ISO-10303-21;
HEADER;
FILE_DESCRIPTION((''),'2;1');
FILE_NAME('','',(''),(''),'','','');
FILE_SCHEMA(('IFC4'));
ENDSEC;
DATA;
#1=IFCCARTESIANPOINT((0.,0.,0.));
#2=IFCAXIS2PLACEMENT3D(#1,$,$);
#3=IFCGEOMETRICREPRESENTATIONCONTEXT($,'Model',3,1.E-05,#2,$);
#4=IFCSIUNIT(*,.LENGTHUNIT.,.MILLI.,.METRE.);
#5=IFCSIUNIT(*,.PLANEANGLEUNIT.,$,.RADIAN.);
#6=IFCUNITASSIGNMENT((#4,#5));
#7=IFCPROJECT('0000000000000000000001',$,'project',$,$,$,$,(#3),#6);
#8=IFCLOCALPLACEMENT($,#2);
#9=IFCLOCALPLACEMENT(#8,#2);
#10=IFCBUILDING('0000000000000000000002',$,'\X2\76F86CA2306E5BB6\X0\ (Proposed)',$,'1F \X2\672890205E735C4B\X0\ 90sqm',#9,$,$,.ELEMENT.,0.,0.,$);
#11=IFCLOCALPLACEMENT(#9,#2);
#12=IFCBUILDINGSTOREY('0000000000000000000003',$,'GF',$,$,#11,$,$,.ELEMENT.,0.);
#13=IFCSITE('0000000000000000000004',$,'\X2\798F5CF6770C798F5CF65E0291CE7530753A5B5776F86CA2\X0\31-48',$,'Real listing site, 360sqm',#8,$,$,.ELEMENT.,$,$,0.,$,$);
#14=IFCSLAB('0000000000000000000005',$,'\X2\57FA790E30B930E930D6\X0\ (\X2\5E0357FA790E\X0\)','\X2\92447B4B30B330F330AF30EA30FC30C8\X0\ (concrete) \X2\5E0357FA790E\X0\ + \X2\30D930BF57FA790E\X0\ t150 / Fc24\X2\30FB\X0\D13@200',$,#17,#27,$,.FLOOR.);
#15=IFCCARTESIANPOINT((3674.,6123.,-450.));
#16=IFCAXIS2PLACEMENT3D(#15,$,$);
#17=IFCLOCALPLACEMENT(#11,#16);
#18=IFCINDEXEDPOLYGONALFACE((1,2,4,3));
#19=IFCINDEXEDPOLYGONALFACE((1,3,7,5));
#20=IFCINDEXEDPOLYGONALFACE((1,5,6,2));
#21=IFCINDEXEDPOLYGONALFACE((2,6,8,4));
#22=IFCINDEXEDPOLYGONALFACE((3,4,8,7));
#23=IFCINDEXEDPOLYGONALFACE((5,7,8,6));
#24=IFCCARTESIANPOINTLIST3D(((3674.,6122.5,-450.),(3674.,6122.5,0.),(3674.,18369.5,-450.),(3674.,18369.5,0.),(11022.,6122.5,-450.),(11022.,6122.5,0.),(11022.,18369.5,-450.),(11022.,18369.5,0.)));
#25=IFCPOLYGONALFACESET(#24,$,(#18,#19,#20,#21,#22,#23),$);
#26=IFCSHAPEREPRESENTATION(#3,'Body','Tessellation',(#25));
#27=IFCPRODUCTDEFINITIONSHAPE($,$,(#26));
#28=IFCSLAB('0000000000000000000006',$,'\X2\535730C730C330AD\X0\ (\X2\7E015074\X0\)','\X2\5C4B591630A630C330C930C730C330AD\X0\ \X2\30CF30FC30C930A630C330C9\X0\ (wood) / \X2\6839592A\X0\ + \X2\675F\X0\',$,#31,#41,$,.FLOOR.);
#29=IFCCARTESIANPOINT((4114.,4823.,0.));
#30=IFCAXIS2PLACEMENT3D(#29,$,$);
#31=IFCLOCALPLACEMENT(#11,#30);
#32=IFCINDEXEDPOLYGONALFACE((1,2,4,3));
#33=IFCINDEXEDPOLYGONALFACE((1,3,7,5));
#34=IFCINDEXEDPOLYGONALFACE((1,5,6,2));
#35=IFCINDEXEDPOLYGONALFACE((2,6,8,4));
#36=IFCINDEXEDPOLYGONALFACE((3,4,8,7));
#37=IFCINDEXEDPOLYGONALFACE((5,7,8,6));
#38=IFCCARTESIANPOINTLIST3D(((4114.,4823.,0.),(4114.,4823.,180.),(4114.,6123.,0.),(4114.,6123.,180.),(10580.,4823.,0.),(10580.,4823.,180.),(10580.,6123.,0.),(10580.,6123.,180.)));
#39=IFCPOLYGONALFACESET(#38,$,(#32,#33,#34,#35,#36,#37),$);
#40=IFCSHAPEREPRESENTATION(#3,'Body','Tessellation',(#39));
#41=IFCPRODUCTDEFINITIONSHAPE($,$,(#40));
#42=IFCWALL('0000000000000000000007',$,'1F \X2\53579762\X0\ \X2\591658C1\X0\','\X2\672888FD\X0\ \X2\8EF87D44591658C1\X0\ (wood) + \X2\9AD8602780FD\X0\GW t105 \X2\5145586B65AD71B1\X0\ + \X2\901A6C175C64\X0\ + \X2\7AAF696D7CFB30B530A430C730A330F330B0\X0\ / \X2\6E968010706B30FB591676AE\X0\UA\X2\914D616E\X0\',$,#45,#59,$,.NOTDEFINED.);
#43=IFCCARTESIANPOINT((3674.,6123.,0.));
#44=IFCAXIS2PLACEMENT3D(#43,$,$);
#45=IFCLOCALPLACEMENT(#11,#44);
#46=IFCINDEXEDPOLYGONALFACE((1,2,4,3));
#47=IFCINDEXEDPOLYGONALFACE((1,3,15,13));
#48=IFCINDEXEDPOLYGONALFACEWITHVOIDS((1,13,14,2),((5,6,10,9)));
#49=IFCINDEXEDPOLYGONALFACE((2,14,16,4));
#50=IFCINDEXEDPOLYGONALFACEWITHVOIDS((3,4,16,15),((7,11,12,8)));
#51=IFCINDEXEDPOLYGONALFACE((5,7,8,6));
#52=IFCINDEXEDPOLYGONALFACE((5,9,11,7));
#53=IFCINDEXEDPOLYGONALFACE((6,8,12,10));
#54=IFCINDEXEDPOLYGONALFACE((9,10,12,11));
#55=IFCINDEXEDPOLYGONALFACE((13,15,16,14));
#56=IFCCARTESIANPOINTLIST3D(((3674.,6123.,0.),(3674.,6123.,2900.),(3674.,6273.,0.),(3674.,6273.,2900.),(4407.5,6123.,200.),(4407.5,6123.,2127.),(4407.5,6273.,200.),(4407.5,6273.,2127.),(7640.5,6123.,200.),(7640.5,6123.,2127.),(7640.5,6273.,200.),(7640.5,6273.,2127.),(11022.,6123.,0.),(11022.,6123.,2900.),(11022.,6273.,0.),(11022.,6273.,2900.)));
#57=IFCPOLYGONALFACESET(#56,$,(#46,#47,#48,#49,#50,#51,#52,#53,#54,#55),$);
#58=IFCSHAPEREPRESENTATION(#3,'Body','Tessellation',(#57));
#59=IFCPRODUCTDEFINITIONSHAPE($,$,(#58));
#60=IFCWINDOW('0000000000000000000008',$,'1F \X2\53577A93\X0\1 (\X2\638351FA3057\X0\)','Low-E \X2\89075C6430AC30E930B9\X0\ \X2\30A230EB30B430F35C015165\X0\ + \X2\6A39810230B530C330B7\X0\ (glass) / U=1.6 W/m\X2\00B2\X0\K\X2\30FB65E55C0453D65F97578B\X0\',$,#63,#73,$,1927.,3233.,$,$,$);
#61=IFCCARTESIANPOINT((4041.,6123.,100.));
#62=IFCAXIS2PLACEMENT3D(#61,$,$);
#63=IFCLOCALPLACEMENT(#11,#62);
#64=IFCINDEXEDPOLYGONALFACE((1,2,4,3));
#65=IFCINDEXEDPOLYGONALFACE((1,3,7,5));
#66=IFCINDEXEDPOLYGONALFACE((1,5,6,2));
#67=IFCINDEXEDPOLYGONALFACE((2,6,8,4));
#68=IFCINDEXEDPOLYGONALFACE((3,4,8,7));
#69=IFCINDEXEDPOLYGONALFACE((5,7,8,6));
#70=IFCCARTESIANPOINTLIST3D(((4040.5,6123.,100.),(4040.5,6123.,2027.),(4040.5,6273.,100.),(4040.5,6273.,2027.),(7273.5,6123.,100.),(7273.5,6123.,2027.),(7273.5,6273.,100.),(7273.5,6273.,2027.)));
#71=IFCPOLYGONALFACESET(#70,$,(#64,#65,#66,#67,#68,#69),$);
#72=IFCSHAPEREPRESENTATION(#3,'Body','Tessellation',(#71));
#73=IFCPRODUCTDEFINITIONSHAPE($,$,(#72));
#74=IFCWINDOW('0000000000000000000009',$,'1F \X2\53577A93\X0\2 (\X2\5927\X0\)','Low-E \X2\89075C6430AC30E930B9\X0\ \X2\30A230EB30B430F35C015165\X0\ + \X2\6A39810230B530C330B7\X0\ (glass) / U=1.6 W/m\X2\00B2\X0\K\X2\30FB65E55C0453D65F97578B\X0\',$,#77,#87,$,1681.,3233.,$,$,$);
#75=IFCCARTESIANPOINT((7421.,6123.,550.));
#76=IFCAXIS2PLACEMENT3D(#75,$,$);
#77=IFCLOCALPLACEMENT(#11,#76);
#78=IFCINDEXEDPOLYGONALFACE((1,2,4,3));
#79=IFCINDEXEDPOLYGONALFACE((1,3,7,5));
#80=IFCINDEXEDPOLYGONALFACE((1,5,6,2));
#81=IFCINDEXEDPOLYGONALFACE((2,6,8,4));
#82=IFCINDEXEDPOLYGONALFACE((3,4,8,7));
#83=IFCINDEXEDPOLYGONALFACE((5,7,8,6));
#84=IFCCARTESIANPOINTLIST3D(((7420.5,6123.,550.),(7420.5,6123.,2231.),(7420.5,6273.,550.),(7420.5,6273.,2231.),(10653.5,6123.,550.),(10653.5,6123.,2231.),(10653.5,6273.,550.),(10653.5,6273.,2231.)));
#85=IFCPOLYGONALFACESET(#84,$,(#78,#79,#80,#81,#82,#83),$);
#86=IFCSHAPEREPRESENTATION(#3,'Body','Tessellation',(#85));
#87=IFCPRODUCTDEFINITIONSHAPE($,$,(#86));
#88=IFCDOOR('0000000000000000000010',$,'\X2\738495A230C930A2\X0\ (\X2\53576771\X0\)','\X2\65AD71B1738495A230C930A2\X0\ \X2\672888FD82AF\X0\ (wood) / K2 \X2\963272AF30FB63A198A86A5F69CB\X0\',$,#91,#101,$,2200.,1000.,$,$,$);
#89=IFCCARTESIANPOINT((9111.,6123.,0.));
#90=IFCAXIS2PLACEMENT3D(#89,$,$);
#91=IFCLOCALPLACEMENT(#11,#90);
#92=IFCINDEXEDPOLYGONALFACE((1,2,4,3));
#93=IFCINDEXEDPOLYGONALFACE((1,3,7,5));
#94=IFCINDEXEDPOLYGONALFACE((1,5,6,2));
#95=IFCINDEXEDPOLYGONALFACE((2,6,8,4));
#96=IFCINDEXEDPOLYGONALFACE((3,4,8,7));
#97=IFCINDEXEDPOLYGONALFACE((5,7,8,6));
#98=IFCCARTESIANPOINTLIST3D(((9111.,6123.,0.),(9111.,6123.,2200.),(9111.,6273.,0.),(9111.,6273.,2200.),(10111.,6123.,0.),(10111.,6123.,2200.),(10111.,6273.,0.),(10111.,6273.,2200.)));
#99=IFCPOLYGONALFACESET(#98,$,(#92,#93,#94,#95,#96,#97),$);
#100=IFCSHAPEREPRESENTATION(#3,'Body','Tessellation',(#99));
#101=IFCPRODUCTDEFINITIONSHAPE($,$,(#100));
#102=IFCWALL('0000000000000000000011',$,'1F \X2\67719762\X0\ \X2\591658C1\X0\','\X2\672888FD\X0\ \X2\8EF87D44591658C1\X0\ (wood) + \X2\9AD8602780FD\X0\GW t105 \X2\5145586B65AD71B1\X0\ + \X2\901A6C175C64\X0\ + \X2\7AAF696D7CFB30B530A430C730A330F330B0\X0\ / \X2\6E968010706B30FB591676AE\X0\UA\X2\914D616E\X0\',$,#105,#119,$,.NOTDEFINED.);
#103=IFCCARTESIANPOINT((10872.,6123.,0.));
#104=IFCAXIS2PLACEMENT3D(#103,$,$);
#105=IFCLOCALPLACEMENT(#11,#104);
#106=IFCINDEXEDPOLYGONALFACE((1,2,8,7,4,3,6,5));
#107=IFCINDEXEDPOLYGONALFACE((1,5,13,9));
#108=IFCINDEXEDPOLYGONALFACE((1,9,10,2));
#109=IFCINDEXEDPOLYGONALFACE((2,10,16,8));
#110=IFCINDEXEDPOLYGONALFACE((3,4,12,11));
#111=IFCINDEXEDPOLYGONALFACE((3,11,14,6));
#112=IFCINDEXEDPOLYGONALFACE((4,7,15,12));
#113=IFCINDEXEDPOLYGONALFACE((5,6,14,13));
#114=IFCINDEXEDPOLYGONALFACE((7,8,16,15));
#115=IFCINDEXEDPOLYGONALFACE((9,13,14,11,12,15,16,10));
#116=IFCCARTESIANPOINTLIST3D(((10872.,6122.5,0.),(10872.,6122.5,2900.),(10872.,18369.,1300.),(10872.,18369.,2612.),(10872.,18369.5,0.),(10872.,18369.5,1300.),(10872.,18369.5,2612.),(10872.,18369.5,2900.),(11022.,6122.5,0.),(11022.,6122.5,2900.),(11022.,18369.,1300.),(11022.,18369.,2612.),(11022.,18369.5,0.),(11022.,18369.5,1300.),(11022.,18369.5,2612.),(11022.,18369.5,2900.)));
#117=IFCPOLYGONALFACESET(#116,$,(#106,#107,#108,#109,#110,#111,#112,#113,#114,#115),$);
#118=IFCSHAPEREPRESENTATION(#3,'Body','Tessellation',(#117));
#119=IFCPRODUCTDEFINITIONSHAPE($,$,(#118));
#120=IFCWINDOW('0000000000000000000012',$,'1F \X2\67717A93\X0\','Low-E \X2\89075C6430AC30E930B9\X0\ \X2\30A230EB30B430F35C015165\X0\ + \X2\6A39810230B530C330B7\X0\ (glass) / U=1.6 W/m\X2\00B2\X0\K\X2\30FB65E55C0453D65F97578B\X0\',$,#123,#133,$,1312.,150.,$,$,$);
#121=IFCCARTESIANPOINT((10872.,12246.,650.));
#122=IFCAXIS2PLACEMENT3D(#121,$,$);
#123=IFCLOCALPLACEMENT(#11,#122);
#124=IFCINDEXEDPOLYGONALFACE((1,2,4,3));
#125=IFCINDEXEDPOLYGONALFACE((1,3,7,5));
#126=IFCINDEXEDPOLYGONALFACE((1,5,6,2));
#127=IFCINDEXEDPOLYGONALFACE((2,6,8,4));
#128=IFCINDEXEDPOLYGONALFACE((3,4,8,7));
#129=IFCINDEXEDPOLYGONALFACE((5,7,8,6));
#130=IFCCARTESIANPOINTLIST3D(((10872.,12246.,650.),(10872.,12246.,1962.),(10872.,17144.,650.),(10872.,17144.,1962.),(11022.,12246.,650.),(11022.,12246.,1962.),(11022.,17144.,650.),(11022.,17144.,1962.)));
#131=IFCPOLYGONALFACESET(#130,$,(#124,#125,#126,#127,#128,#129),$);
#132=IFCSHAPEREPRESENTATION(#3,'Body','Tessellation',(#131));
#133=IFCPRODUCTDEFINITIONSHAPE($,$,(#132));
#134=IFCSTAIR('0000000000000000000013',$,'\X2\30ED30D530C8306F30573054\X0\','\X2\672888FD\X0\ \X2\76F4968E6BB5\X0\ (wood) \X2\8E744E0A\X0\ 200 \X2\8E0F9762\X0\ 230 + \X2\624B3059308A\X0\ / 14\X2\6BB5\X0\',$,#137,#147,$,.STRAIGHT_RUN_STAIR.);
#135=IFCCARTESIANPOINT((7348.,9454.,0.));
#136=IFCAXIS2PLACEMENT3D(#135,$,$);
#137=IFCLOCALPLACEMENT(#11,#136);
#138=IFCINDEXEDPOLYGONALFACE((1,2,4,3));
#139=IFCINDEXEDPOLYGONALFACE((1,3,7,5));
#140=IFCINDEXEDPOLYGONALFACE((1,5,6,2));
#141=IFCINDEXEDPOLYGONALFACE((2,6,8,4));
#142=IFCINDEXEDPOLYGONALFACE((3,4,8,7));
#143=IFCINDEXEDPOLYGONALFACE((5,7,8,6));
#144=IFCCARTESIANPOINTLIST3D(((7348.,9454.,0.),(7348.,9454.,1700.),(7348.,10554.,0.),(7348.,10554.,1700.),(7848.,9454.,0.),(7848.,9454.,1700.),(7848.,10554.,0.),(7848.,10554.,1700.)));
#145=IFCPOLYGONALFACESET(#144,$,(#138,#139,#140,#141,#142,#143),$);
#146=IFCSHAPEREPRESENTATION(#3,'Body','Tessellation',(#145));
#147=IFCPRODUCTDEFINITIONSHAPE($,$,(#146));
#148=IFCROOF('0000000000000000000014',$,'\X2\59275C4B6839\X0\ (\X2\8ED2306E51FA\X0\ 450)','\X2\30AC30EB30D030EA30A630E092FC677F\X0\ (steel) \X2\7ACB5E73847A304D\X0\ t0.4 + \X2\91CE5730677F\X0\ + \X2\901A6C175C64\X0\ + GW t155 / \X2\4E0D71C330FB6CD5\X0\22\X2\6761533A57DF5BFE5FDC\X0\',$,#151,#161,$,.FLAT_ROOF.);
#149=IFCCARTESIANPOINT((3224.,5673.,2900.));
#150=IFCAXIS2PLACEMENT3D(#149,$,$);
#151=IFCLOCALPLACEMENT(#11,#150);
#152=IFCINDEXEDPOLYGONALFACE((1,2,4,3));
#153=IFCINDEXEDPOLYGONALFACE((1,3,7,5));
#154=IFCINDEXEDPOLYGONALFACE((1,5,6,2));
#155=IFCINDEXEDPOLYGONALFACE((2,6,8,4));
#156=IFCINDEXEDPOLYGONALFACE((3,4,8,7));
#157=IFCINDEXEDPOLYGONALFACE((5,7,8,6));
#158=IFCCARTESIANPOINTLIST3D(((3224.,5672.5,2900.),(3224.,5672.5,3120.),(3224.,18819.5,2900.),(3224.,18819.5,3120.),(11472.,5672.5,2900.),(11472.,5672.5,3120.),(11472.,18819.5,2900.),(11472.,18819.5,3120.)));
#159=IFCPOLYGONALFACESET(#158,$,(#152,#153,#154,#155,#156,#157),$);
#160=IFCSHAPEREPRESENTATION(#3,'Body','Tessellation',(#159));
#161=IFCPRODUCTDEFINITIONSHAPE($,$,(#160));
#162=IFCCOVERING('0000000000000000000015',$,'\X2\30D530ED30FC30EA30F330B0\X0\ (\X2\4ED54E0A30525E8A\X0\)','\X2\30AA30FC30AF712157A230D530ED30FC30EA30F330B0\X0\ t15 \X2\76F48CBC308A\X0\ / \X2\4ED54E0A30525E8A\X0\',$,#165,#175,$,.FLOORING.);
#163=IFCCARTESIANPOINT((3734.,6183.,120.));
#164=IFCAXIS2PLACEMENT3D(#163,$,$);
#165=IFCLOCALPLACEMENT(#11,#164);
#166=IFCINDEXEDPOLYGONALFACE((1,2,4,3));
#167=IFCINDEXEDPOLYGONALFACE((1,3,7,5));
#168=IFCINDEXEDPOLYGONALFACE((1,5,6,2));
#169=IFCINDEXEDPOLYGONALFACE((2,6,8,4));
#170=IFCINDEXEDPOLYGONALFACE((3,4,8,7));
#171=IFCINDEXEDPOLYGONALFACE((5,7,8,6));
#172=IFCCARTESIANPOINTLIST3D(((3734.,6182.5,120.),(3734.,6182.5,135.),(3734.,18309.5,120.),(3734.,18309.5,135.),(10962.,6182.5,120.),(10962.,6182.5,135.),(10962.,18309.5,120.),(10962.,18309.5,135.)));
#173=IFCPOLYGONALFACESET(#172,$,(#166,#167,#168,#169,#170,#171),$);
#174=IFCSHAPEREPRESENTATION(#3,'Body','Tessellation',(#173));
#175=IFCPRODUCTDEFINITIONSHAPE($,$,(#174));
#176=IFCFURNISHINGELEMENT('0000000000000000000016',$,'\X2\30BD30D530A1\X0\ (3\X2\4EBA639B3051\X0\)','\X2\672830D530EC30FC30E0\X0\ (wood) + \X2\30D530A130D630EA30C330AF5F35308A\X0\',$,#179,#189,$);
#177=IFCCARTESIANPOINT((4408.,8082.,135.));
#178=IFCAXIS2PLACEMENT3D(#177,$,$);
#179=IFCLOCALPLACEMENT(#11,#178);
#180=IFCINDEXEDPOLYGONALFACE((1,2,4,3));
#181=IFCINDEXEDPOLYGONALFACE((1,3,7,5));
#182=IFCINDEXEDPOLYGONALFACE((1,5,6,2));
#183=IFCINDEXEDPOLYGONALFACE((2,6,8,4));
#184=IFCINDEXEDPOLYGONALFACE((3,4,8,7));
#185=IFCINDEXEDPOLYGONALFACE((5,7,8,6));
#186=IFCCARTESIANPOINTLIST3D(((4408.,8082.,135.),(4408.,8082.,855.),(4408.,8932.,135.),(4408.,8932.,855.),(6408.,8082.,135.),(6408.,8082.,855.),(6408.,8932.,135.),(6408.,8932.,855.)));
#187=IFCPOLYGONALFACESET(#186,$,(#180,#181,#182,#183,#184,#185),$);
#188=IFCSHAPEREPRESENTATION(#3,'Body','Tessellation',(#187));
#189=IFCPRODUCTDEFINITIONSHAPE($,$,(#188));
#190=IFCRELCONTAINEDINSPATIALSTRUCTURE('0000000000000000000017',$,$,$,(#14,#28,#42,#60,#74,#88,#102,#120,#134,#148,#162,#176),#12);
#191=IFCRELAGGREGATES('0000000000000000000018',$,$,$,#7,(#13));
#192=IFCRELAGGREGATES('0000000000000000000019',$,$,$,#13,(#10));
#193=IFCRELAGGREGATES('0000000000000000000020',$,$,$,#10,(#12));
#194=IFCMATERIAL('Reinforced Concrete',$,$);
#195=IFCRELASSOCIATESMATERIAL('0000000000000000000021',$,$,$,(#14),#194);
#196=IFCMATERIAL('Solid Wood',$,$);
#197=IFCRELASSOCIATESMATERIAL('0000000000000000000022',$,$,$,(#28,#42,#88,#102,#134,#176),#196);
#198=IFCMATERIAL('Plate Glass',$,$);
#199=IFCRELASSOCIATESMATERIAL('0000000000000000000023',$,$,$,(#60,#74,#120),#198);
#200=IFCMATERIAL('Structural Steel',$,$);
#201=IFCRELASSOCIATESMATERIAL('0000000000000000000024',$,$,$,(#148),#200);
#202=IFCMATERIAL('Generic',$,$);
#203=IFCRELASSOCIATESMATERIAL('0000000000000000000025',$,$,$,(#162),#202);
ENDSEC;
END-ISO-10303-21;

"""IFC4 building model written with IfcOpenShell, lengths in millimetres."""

from ifc_helpers import new_model, si_unit, frame, frame_2d, origin, place, context, project, spatial, rectangle, extrude, material, element, fill, save


model = new_model("IFC4")

# Units and contexts
model_context = context("Model", 3, precision=1e-05, world=origin())
ifc_project = project(units=[si_unit("LENGTHUNIT", "METRE", prefix="MILLI"), si_unit("PLANEANGLEUNIT", "RADIAN")], contexts=[model_context])

# Site, building, storey
site_placement = place(None, origin())
site = spatial("IfcSite", under=ifc_project, at=site_placement, Name="福島県福島市野田町字相沢31-48", ObjectType="Real listing site, 360sqm", CompositionType="ELEMENT", RefElevation=0.0)
building_placement = place(site_placement, origin())
building = spatial("IfcBuilding", under=site, at=building_placement, Name="相沢の家 (Proposed)", ObjectType="1F 木造平屋 90sqm", CompositionType="ELEMENT", ElevationOfRefHeight=0.0, ElevationOfTerrain=0.0)
storey_placement = place(building_placement, origin())
storey = spatial("IfcBuildingStorey", under=building, at=storey_placement, Name="GF", CompositionType="ELEMENT", Elevation=0.0)

# Slabs
ifc_material_1 = material(Name="Reinforced Concrete")
slab_1_placement = place(storey_placement, frame((3674.0, 6123.0, -450.0)))
element("IfcSlab", 1, at=slab_1_placement, inside=storey, material=ifc_material_1, Name="基礎スラブ (布基礎)", Description="鉄筋コンクリート (concrete) 布基礎 + ベタ基礎 t150 / Fc24・D13@200", PredefinedType="FLOOR", context=model_context, shape_type="SweptSolid", body=[
    extrude(rectangle(XDim=7348.0, YDim=12247.0, at=frame_2d((3674.0, 6123.0))), frame((3674.0, 6123.0, -450.0)), (0.0, 0.0, 1.0), 450.0),
])
ifc_material_2 = material(Name="Solid Wood")
slab_2_placement = place(storey_placement, frame((4114.0, 4823.0, 0.0)))
element("IfcSlab", 2, at=slab_2_placement, inside=storey, material=ifc_material_2, Name="南デッキ (縁側)", Description="屋外ウッドデッキ ハードウッド (wood) / 根太 + 束", PredefinedType="FLOOR", context=model_context, shape_type="SweptSolid", body=[
    extrude(rectangle(XDim=6466.0, YDim=1300.0, at=frame_2d((3233.0, 650.0))), frame((4114.0, 4823.0, 0.0)), (0.0, 0.0, 1.0), 180.0),
])

# Wall, openings, windows, door
wall_1_placement = place(storey_placement, frame((3674.0, 6123.0, 0.0)))
wall_1 = element("IfcWall", 3, at=wall_1_placement, inside=storey, material=ifc_material_2, Name="1F 南面 外壁", Description="木製 軸組外壁 (wood) + 高性能GW t105 充填断熱 + 通気層 + 窯業系サイディング / 準耐火・外皮UA配慮", PredefinedType="NOTDEFINED", context=model_context, shape_type="SweptSolid", body=[
    extrude(rectangle(XDim=7348.0, YDim=150.0, at=frame_2d((3674.0, 75.0))), frame((3674.0, 6123.0, 0.0)), (0.0, 0.0, 1.0), 2900.0),
])
opening_1_placement = place(storey_placement, frame((4041.0, 6123.0, 100.0)))
opening_1 = element("IfcOpeningElement", 4, at=opening_1_placement, cuts=wall_1, PredefinedType="NOTDEFINED", context=model_context, shape_type="SweptSolid", body=[
    extrude(rectangle(XDim=3233.0, YDim=150.0, at=frame_2d((1616.0, 75.0))), frame((4041.0, 6123.0, 100.0)), (0.0, 0.0, 1.0), 1927.0),
])
opening_2_placement = place(storey_placement, frame((7421.0, 6123.0, 550.0)))
opening_2 = element("IfcOpeningElement", 5, at=opening_2_placement, cuts=wall_1, PredefinedType="NOTDEFINED", context=model_context, shape_type="SweptSolid", body=[
    extrude(rectangle(XDim=3233.0, YDim=150.0, at=frame_2d((1616.0, 75.0))), frame((7421.0, 6123.0, 550.0)), (0.0, 0.0, 1.0), 1681.0),
])
opening_3_placement = place(storey_placement, frame((9111.0, 6123.0, 0.0)))
opening_3 = element("IfcOpeningElement", 6, at=opening_3_placement, cuts=wall_1, PredefinedType="NOTDEFINED", context=model_context, shape_type="SweptSolid", body=[
    extrude(rectangle(XDim=1000.0, YDim=150.0, at=frame_2d((500.0, 75.0))), frame((9111.0, 6123.0, 0.0)), (0.0, 0.0, 1.0), 2200.0),
])
ifc_material_3 = material(Name="Plate Glass")
window_1_placement = place(storey_placement, frame((4041.0, 6123.0, 100.0)))
window_1 = element("IfcWindow", 7, at=window_1_placement, inside=storey, material=ifc_material_3, Name="1F 南窓1 (掃出し)", Description="Low-E 複層ガラス アルゴン封入 + 樹脂サッシ (glass) / U=1.6 W/m²K・日射取得型", OverallHeight=1927.0, OverallWidth=3233.0, context=model_context, shape_type="SweptSolid", body=[
    extrude(rectangle(XDim=3233.0, YDim=150.0, at=frame_2d((1616.0, 75.0))), frame((4041.0, 6123.0, 100.0)), (0.0, 0.0, 1.0), 1927.0),
])
fill(opening_1, window_1)
window_2_placement = place(storey_placement, frame((7421.0, 6123.0, 550.0)))
window_2 = element("IfcWindow", 8, at=window_2_placement, inside=storey, material=ifc_material_3, Name="1F 南窓2 (大)", Description="Low-E 複層ガラス アルゴン封入 + 樹脂サッシ (glass) / U=1.6 W/m²K・日射取得型", OverallHeight=1681.0, OverallWidth=3233.0, context=model_context, shape_type="SweptSolid", body=[
    extrude(rectangle(XDim=3233.0, YDim=150.0, at=frame_2d((1616.0, 75.0))), frame((7421.0, 6123.0, 550.0)), (0.0, 0.0, 1.0), 1681.0),
])
fill(opening_2, window_2)
door_placement = place(storey_placement, frame((9111.0, 6123.0, 0.0)))
door = element("IfcDoor", 9, at=door_placement, inside=storey, material=ifc_material_2, Name="玄関ドア (南東)", Description="断熱玄関ドア 木製芯 (wood) / K2 防犯・採風機構", OverallHeight=2200.0, OverallWidth=1000.0, context=model_context, shape_type="SweptSolid", body=[
    extrude(rectangle(XDim=1000.0, YDim=150.0, at=frame_2d((500.0, 75.0))), frame((9111.0, 6123.0, 0.0)), (0.0, 0.0, 1.0), 2200.0),
])
fill(opening_3, door)

# Wall, opening, window
wall_2_placement = place(storey_placement, frame((10872.0, 6123.0, 0.0)))
wall_2 = element("IfcWall", 10, at=wall_2_placement, inside=storey, material=ifc_material_2, Name="1F 東面 外壁", Description="木製 軸組外壁 (wood) + 高性能GW t105 充填断熱 + 通気層 + 窯業系サイディング / 準耐火・外皮UA配慮", PredefinedType="NOTDEFINED", context=model_context, shape_type="SweptSolid", body=[
    extrude(rectangle(XDim=150.0, YDim=12247.0, at=frame_2d((75.0, 6123.0))), frame((10872.0, 6123.0, 0.0)), (0.0, 0.0, 1.0), 2900.0),
])
opening_4_placement = place(storey_placement, frame((10872.0, 12246.0, 650.0)))
opening_4 = element("IfcOpeningElement", 11, at=opening_4_placement, cuts=wall_2, PredefinedType="NOTDEFINED", context=model_context, shape_type="SweptSolid", body=[
    extrude(rectangle(XDim=150.0, YDim=4898.0, at=frame_2d((75.0, 2449.0))), frame((10872.0, 12246.0, 650.0)), (0.0, 0.0, 1.0), 1312.0),
])
window_3_placement = place(storey_placement, frame((10872.0, 12246.0, 650.0)))
window_3 = element("IfcWindow", 12, at=window_3_placement, inside=storey, material=ifc_material_3, Name="1F 東窓", Description="Low-E 複層ガラス アルゴン封入 + 樹脂サッシ (glass) / U=1.6 W/m²K・日射取得型", OverallHeight=1312.0, OverallWidth=150.0, context=model_context, shape_type="SweptSolid", body=[
    extrude(rectangle(XDim=150.0, YDim=4898.0, at=frame_2d((75.0, 2449.0))), frame((10872.0, 12246.0, 650.0)), (0.0, 0.0, 1.0), 1312.0),
])
fill(opening_4, window_3)

# Stair
stair_placement = place(storey_placement, frame((7348.0, 9454.0, 0.0)))
element("IfcStair", 13, at=stair_placement, inside=storey, material=ifc_material_2, Name="ロフトはしご", Description="木製 直階段 (wood) 蹴上 200 踏面 230 + 手すり / 14段", PredefinedType="STRAIGHT_RUN_STAIR", context=model_context, shape_type="SweptSolid", body=[
    extrude(rectangle(XDim=500.0, YDim=1100.0, at=frame_2d((250.0, 550.0))), frame((7348.0, 9454.0, 0.0)), (0.0, 0.0, 1.0), 1700.0),
])

# Roof
ifc_material_4 = material(Name="Structural Steel")
roof_placement = place(storey_placement, frame((3224.0, 5673.0, 2900.0)))
element("IfcRoof", 14, at=roof_placement, inside=storey, material=ifc_material_4, Name="大屋根 (軒の出 450)", Description="ガルバリウム鋼板 (steel) 立平葺き t0.4 + 野地板 + 通気層 + GW t155 / 不燃・法22条区域対応", PredefinedType="FLAT_ROOF", context=model_context, shape_type="SweptSolid", body=[
    extrude(rectangle(XDim=8248.0, YDim=13147.0, at=frame_2d((4124.0, 6573.0))), frame((3224.0, 5673.0, 2900.0)), (0.0, 0.0, 1.0), 220.0),
])

# Covering
ifc_material_5 = material(Name="Generic")
covering_placement = place(storey_placement, frame((3734.0, 6183.0, 120.0)))
element("IfcCovering", 15, at=covering_placement, inside=storey, material=ifc_material_5, Name="フローリング (仕上げ床)", Description="オーク無垢フローリング t15 直貼り / 仕上げ床", PredefinedType="FLOORING", context=model_context, shape_type="SweptSolid", body=[
    extrude(rectangle(XDim=7228.0, YDim=12127.0, at=frame_2d((3614.0, 6063.0))), frame((3734.0, 6183.0, 120.0)), (0.0, 0.0, 1.0), 15.0),
])

# Furnishing element
furnishing_1_placement = place(storey_placement, frame((4408.0, 8082.0, 135.0)))
element("IfcFurnishingElement", 16, at=furnishing_1_placement, inside=storey, material=ifc_material_2, Name="ソファ (3人掛け)", Description="木フレーム (wood) + ファブリック張り", context=model_context, shape_type="SweptSolid", body=[
    extrude(rectangle(XDim=2000.0, YDim=850.0, at=frame_2d((1000.0, 425.0))), frame((4408.0, 8082.0, 135.0)), (0.0, 0.0, 1.0), 720.0),
])

save(model, "model.ifc")
